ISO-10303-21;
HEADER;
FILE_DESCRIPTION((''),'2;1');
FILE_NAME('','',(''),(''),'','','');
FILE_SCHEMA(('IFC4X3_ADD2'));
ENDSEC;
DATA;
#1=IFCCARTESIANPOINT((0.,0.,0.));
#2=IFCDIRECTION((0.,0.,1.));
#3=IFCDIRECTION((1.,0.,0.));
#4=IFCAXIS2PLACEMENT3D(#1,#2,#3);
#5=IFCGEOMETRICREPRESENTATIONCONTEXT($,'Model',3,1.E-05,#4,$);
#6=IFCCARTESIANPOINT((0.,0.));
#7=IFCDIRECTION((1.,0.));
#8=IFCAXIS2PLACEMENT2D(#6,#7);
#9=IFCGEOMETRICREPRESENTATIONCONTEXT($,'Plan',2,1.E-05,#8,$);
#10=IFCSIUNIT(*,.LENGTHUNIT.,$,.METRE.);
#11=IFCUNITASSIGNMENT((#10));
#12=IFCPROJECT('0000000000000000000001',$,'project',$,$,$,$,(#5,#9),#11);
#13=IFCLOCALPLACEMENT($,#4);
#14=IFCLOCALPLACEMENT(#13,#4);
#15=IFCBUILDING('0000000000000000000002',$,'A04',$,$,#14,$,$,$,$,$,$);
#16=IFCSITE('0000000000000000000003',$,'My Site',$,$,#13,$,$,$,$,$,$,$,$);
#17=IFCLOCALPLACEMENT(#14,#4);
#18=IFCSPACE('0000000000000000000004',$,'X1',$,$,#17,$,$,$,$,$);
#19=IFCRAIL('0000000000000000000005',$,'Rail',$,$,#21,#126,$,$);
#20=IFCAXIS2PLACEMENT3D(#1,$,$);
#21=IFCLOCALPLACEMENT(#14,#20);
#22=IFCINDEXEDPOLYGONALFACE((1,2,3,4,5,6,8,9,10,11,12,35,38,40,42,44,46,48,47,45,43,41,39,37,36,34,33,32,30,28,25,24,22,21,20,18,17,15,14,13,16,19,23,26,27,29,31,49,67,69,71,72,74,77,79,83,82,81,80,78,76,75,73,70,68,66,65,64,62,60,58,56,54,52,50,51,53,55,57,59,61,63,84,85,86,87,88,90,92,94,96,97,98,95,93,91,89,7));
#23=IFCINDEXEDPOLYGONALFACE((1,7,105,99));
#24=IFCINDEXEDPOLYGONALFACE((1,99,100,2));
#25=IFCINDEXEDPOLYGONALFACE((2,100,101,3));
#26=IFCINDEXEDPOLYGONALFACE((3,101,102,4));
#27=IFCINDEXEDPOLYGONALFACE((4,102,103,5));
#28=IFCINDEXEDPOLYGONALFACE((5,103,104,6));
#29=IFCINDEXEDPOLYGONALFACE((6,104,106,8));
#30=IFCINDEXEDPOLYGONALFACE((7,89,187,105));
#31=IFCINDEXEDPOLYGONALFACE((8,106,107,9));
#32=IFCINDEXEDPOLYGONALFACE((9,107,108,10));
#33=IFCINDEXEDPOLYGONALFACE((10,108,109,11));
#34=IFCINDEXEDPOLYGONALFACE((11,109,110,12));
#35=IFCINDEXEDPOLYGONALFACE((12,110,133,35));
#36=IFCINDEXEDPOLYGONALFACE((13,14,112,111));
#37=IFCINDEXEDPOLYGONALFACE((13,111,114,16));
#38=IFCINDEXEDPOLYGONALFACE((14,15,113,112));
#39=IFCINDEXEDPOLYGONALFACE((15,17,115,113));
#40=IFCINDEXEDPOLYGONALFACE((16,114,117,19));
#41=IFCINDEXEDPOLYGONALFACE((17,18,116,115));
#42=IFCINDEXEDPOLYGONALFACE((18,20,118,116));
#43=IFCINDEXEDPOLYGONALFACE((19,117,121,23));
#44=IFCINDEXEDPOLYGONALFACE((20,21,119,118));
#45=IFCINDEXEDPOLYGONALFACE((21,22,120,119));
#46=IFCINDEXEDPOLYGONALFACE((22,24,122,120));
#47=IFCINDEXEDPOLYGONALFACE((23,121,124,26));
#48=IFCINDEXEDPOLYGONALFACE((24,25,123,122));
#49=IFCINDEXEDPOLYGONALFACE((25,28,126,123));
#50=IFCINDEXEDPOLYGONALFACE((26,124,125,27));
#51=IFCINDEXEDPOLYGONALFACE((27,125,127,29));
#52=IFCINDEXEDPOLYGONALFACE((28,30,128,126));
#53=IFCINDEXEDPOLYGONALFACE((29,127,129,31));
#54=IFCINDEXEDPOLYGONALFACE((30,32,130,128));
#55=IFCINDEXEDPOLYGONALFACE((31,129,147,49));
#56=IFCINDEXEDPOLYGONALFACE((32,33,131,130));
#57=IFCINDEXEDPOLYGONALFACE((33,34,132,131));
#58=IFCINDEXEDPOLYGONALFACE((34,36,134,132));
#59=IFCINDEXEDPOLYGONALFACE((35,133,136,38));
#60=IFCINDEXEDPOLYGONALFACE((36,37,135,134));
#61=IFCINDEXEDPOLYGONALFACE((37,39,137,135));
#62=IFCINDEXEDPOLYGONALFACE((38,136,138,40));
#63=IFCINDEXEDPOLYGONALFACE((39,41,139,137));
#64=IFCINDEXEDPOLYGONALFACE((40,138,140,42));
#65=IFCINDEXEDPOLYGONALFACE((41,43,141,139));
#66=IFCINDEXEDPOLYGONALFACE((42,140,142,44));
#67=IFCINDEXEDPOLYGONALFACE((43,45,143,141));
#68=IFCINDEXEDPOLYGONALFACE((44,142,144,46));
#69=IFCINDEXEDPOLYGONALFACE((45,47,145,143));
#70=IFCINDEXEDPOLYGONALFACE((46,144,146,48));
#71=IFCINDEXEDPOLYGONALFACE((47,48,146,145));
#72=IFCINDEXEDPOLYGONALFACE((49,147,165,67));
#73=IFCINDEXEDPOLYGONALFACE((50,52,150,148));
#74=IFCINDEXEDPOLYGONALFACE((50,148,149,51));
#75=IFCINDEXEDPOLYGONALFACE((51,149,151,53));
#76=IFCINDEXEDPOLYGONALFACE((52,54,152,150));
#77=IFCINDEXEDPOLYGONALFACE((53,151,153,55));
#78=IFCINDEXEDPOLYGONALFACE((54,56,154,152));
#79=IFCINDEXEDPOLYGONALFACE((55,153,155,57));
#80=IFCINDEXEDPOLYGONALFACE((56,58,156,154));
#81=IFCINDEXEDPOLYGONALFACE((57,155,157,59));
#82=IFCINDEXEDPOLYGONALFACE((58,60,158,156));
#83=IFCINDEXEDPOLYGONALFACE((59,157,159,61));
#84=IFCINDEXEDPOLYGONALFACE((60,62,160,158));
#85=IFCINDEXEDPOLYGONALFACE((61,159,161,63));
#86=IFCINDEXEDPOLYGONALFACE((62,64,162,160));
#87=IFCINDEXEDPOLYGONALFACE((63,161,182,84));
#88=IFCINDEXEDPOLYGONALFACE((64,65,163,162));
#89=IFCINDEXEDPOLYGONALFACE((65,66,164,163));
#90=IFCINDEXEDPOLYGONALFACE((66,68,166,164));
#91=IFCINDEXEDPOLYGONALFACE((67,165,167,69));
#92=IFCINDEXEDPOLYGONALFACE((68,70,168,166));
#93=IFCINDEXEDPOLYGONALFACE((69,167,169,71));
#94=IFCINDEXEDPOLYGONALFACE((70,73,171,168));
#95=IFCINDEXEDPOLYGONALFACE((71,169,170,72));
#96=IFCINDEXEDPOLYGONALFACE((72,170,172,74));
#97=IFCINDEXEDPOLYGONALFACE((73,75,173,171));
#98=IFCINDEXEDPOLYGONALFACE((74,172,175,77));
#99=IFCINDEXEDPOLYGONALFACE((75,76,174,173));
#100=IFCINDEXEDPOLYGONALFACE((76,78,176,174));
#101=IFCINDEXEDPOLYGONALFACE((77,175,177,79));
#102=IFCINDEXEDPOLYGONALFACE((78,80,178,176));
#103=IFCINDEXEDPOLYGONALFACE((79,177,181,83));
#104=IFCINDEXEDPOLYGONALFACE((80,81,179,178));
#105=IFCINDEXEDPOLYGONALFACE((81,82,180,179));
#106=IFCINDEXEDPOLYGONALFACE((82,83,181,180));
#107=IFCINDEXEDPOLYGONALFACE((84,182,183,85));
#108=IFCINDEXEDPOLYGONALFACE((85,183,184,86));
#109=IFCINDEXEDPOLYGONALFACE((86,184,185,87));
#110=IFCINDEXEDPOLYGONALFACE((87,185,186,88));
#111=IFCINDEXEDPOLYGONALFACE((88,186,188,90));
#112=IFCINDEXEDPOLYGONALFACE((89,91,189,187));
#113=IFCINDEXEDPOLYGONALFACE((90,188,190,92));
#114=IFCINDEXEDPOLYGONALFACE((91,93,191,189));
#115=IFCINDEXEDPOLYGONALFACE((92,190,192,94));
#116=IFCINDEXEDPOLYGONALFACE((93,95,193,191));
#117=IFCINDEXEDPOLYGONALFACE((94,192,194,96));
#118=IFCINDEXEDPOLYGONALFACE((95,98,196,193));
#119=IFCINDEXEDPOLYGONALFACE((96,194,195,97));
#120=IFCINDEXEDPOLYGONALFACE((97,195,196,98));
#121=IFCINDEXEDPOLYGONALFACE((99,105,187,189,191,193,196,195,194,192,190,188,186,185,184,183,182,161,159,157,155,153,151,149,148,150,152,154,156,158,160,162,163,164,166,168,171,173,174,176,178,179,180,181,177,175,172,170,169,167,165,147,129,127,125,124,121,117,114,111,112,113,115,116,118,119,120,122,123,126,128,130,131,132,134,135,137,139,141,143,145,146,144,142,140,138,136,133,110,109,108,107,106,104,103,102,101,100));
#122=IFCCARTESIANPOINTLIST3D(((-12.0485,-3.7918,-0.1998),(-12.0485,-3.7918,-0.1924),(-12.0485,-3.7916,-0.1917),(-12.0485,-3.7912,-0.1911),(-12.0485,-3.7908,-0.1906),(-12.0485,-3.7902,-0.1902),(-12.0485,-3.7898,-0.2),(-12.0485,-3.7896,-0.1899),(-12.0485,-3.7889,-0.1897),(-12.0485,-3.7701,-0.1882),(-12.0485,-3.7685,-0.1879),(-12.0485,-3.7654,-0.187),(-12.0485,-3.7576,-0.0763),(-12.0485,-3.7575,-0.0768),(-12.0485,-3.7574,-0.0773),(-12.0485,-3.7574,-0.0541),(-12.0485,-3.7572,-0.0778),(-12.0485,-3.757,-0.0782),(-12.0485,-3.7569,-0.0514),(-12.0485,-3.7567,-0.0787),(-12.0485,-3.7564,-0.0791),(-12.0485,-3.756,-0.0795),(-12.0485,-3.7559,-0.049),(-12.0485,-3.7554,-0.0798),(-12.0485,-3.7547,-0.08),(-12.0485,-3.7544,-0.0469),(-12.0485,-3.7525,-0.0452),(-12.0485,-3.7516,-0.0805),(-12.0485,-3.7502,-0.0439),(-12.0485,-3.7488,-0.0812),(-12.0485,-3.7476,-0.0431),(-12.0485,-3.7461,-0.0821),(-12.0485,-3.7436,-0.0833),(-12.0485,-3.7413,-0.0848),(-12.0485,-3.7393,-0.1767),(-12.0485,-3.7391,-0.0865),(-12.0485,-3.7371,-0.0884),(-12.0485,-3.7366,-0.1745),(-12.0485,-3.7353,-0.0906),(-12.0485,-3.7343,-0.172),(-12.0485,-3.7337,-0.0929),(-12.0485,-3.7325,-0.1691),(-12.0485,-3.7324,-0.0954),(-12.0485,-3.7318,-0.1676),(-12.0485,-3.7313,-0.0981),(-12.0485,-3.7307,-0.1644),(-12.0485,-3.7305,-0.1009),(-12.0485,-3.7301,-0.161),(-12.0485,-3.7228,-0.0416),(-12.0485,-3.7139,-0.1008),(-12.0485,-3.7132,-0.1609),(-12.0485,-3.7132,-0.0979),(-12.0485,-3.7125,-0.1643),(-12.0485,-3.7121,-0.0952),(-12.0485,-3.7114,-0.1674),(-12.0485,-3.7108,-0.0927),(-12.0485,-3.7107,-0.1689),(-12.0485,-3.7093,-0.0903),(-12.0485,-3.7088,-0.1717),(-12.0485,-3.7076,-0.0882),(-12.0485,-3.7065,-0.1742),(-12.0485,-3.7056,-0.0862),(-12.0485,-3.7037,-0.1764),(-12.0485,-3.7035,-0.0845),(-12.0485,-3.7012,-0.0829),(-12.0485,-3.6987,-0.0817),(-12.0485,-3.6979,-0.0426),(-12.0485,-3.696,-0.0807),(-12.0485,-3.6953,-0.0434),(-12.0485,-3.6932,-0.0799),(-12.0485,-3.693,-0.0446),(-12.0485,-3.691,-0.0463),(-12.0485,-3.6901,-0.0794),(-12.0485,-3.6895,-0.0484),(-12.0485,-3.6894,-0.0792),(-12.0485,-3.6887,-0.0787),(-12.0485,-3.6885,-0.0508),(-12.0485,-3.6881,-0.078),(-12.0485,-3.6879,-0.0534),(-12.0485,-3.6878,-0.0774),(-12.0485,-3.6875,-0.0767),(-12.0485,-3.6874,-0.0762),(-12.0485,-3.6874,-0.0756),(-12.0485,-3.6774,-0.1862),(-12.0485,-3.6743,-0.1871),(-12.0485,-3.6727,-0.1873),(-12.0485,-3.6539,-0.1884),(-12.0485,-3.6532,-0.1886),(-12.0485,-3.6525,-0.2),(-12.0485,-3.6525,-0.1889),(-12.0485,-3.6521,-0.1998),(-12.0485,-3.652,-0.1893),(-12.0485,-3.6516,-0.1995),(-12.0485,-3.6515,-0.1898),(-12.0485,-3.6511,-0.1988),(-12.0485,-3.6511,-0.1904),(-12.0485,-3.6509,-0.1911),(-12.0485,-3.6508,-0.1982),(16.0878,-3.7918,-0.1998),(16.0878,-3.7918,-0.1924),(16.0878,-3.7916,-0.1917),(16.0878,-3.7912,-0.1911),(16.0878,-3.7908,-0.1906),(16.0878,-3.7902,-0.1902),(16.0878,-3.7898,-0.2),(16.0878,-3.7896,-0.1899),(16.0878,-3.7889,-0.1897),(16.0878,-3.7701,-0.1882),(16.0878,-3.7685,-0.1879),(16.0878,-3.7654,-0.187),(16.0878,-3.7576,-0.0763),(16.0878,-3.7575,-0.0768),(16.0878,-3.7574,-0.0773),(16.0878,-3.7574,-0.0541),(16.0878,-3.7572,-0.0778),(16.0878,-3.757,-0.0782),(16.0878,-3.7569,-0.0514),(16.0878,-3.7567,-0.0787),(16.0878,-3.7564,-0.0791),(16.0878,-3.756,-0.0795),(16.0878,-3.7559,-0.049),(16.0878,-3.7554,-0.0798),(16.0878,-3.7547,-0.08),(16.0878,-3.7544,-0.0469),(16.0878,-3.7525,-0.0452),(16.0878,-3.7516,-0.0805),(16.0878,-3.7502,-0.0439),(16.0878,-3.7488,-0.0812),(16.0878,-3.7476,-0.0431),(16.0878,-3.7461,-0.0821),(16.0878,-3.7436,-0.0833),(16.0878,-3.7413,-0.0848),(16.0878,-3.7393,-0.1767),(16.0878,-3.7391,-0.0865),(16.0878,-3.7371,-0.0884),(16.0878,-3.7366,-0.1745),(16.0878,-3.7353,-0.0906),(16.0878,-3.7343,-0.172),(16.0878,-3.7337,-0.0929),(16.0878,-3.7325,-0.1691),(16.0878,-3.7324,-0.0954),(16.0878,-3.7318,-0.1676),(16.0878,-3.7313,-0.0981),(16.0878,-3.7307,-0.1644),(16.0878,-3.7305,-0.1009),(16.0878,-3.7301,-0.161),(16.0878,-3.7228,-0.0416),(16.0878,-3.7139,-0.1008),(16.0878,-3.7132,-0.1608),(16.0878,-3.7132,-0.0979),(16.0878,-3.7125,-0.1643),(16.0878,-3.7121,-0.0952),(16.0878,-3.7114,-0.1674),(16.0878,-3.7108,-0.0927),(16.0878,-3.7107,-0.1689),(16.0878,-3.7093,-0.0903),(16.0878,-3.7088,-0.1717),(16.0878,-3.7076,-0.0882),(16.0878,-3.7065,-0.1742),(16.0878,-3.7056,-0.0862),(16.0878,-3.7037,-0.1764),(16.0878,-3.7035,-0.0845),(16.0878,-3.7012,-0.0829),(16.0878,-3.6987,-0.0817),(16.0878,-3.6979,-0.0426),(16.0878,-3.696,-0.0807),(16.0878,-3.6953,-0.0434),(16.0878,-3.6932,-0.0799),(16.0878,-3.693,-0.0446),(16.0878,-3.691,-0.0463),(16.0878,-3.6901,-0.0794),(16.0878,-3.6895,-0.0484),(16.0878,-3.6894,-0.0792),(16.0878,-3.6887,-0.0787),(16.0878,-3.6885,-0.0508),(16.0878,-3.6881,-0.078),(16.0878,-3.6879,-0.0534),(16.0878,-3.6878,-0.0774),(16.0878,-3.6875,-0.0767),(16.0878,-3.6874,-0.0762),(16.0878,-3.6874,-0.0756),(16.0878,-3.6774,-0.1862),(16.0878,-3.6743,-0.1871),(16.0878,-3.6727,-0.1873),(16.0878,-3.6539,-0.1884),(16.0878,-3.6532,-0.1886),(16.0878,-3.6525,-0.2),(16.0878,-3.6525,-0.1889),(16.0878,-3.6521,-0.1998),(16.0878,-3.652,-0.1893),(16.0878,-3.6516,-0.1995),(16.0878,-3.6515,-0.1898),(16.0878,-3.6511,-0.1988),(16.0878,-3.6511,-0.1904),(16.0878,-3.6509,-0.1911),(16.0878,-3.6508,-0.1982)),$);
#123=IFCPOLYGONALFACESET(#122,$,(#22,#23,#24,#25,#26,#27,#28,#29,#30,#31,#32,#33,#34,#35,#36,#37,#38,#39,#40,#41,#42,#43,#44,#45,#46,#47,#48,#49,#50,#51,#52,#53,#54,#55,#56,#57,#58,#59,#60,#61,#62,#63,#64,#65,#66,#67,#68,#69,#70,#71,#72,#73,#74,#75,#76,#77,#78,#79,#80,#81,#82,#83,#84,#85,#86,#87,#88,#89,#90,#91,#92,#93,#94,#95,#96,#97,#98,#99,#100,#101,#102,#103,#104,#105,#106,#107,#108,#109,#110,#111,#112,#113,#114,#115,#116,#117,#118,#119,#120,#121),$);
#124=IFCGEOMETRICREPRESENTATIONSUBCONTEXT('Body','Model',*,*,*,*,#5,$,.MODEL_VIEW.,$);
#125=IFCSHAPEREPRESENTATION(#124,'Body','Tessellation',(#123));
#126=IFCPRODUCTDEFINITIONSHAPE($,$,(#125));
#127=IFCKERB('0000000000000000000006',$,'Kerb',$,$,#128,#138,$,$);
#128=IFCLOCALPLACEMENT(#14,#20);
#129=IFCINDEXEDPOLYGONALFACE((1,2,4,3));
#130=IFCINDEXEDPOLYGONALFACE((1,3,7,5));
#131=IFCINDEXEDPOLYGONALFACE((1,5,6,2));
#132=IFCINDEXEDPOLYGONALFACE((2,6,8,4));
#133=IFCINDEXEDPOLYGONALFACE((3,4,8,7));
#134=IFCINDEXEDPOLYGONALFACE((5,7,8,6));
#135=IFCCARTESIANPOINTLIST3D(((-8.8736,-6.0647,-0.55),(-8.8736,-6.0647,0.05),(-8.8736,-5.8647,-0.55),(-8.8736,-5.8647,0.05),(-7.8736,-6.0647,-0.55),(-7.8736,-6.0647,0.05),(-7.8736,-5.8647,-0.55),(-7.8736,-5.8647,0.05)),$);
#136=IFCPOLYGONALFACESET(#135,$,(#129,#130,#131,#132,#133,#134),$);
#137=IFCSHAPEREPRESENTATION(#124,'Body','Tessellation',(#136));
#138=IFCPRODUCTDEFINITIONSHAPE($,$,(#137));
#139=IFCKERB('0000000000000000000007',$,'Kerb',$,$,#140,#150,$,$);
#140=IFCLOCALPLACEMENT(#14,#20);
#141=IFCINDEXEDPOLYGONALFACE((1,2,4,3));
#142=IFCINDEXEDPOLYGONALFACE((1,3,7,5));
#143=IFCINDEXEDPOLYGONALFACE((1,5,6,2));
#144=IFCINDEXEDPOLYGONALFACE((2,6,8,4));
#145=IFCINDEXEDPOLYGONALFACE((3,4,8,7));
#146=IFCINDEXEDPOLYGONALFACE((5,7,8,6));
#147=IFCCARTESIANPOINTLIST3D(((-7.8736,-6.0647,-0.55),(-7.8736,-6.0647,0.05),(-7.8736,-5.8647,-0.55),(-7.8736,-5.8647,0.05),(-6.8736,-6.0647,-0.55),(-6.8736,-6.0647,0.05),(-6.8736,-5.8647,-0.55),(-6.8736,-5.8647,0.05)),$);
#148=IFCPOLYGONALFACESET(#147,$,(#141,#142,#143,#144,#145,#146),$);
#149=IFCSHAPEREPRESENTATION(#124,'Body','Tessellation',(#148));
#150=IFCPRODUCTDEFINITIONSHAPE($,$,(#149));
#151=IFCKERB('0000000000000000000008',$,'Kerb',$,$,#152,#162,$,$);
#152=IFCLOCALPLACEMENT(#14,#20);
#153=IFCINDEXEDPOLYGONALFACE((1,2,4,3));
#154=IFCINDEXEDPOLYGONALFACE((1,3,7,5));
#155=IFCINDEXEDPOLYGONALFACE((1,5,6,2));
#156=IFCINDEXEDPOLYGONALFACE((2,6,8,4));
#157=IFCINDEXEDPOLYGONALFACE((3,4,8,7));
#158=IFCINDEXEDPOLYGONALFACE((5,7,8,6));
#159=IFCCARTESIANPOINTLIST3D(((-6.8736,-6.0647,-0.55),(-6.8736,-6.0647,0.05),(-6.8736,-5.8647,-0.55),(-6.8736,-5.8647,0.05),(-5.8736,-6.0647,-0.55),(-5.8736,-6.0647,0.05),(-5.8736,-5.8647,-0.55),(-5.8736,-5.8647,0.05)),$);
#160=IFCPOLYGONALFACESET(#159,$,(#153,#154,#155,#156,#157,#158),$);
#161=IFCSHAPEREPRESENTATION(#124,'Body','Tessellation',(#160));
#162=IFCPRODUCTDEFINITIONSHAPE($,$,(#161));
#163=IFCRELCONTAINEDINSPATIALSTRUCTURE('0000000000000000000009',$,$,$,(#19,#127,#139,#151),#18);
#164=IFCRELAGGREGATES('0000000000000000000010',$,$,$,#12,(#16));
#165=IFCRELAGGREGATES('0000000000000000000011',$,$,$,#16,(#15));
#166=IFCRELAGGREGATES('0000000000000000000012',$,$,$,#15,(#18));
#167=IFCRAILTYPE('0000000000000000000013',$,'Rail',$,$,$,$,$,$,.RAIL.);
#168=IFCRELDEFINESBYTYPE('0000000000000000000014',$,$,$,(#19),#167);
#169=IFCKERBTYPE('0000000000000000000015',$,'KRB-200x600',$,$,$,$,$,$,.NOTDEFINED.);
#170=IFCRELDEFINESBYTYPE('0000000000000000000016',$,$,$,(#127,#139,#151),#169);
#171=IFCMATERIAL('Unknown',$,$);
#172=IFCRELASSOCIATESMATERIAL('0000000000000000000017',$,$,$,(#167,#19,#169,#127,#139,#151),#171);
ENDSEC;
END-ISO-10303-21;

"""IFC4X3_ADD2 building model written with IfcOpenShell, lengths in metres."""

from ifc_helpers import new_model, si_unit, frame, origin_with_axes, origin_2d_with_axis, place, context, subcontext, project, spatial, indexed_curve, rectangle, outline, extrude, material, material_profile, profile_set, profile_usage, type_object, element, save


model = new_model("IFC4X3_ADD2")

# Units and contexts
model_context = context("Model", 3, precision=1e-05, world=origin_with_axes())
plan_context = context("Plan", 2, precision=1e-05, world=origin_2d_with_axis())
body_context = subcontext(model_context, "Body", "Model", "MODEL_VIEW")
ifc_project = project(units=[si_unit("LENGTHUNIT", "METRE")], contexts=[model_context, plan_context])

# Site, building, space
site_placement = place(None, origin_with_axes())
site = spatial("IfcSite", under=ifc_project, at=site_placement, Name="My Site")
building_placement = place(site_placement, origin_with_axes())
building = spatial("IfcBuilding", under=site, at=building_placement, Name="A04")
space_placement = place(building_placement, origin_with_axes())
space = spatial("IfcSpace", under=building, at=space_placement, Name="X1")

# Shared definitions
ifc_material_1 = material(Name="Unknown")

# Rail
ifc_material_profile_1 = material_profile(ifc_material_1, outline(indexed_curve([(-0.0706, 0.0076), (-0.0704, 0.0083), (-0.0701, 0.0089), (-0.0696, 0.0094), (-0.0691, 0.0098), (-0.0684, 0.0101), (-0.0677, 0.0103), (-0.0489, 0.0118), (-0.0474, 0.0121), (-0.0442, 0.013), (-0.0182, 0.0233), (-0.0154, 0.0255), (-0.0131, 0.028), (-0.0113, 0.0309), (-0.0106, 0.0324), (-0.0095, 0.0356), (-0.009, 0.039), (-0.0094, 0.0991), (-0.0102, 0.1019), (-0.0112, 0.1046), (-0.0126, 0.1071), (-0.0141, 0.1094), (-0.0159, 0.1116), (-0.0179, 0.1135), (-0.0201, 0.1152), (-0.0225, 0.1167), (-0.025, 0.1179), (-0.0276, 0.1188), (-0.0304, 0.1195), (-0.0335, 0.12), (-0.0342, 0.1202), (-0.0348, 0.1205), (-0.0353, 0.1209), (-0.0356, 0.1213), (-0.0358, 0.1218), (-0.0361, 0.1222), (-0.0362, 0.1227), (-0.0363, 0.1232), (-0.0364, 0.1237), (-0.0362, 0.1459), (-0.0358, 0.1486), (-0.0347, 0.151), (-0.0333, 0.1531), (-0.0313, 0.1548), (-0.0291, 0.1561), (-0.0265, 0.1569), (-0.0016, 0.1584), (0.0233, 0.1574), (0.0259, 0.1566), (0.0282, 0.1554), (0.0301, 0.1537), (0.0317, 0.1516), (0.0327, 0.1492), (0.0333, 0.1466), (0.0338, 0.1244), (0.0338, 0.1238), (0.0337, 0.1233), (0.0334, 0.1226), (0.0331, 0.122), (0.0325, 0.1213), (0.0317, 0.1208), (0.031, 0.1206), (0.0279, 0.1201), (0.0252, 0.1193), (0.0225, 0.1183), (0.02, 0.1171), (0.0177, 0.1155), (0.0155, 0.1138), (0.0136, 0.1118), (0.0118, 0.1097), (0.0103, 0.1073), (0.009, 0.1048), (0.008, 0.1021), (0.0073, 0.0992), (0.008, 0.0391), (0.0086, 0.0357), (0.0097, 0.0326), (0.0105, 0.0311), (0.0124, 0.0283), (0.0147, 0.0258), (0.0175, 0.0236), (0.0437, 0.0138), (0.0469, 0.0129), (0.0485, 0.0127), (0.0673, 0.0116), (0.068, 0.0114), (0.0686, 0.0111), (0.0692, 0.0107), (0.0697, 0.0102), (0.07, 0.0096), (0.0703, 0.0089), (0.0703, 0.0018), (0.0701, 0.0012), (0.0696, 0.0005), (0.0691, 0.0002), (0.0687, 0.0), (-0.0687, 0.0), (-0.0706, 0.0002), (-0.0706, 0.0076)])))
ifc_profile_set_1 = profile_set([ifc_material_profile_1])
rail_type = type_object("IfcRailType", Name="Rail", PredefinedType="RAIL", material=ifc_profile_set_1)
ifc_profile_usage_1 = profile_usage(ifc_profile_set_1, cardinal=5)
rail_1_placement = place(space_placement, frame((-12.0485, -3.7212, -0.2), z_axis=(1.0, 0.0, 0.0), x_axis=(0.0, 1.0, 0.0)))
element("IfcRail", 1, at=rail_1_placement, inside=space, type_object=rail_type, material=ifc_profile_usage_1, Name="Rail", context=body_context, shape_type="SweptSolid", body=[
    extrude(outline(indexed_curve([(-0.0706, 0.0076), (-0.0704, 0.0083), (-0.0701, 0.0089), (-0.0696, 0.0094), (-0.0691, 0.0098), (-0.0684, 0.0101), (-0.0677, 0.0103), (-0.0489, 0.0118), (-0.0474, 0.0121), (-0.0442, 0.013), (-0.0182, 0.0233), (-0.0154, 0.0255), (-0.0131, 0.028), (-0.0113, 0.0309), (-0.0106, 0.0324), (-0.0095, 0.0356), (-0.009, 0.039), (-0.0094, 0.0991), (-0.0102, 0.1019), (-0.0112, 0.1046), (-0.0126, 0.1071), (-0.0141, 0.1094), (-0.0159, 0.1116), (-0.0179, 0.1135), (-0.0201, 0.1152), (-0.0225, 0.1167), (-0.025, 0.1179), (-0.0276, 0.1188), (-0.0304, 0.1195), (-0.0335, 0.12), (-0.0342, 0.1202), (-0.0348, 0.1205), (-0.0353, 0.1209), (-0.0356, 0.1213), (-0.0358, 0.1218), (-0.0361, 0.1222), (-0.0362, 0.1227), (-0.0363, 0.1232), (-0.0364, 0.1237), (-0.0362, 0.1459), (-0.0358, 0.1486), (-0.0347, 0.151), (-0.0333, 0.1531), (-0.0313, 0.1548), (-0.0291, 0.1561), (-0.0265, 0.1569), (-0.0016, 0.1584), (0.0233, 0.1574), (0.0259, 0.1566), (0.0282, 0.1554), (0.0301, 0.1537), (0.0317, 0.1516), (0.0327, 0.1492), (0.0333, 0.1466), (0.0338, 0.1244), (0.0338, 0.1238), (0.0337, 0.1233), (0.0334, 0.1226), (0.0331, 0.122), (0.0325, 0.1213), (0.0317, 0.1208), (0.031, 0.1206), (0.0279, 0.1201), (0.0252, 0.1193), (0.0225, 0.1183), (0.02, 0.1171), (0.0177, 0.1155), (0.0155, 0.1138), (0.0136, 0.1118), (0.0118, 0.1097), (0.0103, 0.1073), (0.009, 0.1048), (0.008, 0.1021), (0.0073, 0.0992), (0.008, 0.0391), (0.0086, 0.0357), (0.0097, 0.0326), (0.0105, 0.0311), (0.0124, 0.0283), (0.0147, 0.0258), (0.0175, 0.0236), (0.0437, 0.0138), (0.0469, 0.0129), (0.0485, 0.0127), (0.0673, 0.0116), (0.068, 0.0114), (0.0686, 0.0111), (0.0692, 0.0107), (0.0697, 0.0102), (0.07, 0.0096), (0.0703, 0.0089), (0.0703, 0.0018), (0.0701, 0.0012), (0.0696, 0.0005), (0.0691, 0.0002), (0.0687, 0.0), (-0.0687, 0.0), (-0.0706, 0.0002), (-0.0706, 0.0076)])), origin_with_axes(), (0.0, 0.0, 1.0), 28.1363),
])

# Kerbs
ifc_material_profile_2 = material_profile(ifc_material_1, rectangle(XDim=0.2, YDim=0.6))
ifc_profile_set_2 = profile_set([ifc_material_profile_2])
ifc_profile_usage_2 = profile_usage(ifc_profile_set_2, cardinal=2)
kerb_type = type_object("IfcKerbType", Name="KRB-200x600", PredefinedType="NOTDEFINED", material=ifc_profile_set_2)
kerb_1_placement = place(space_placement, frame((-8.8736, -5.9647, -0.55), z_axis=(1.0, 0.0, 0.0), x_axis=(0.0, 1.0, 0.0)))
element("IfcKerb", 2, at=kerb_1_placement, inside=space, type_object=kerb_type, material=ifc_profile_usage_2, Name="Kerb", context=body_context, shape_type="SweptSolid", body=[
    extrude(rectangle(XDim=0.2, YDim=0.6), frame((0.0, 0.3, 0.0), z_axis=(0.0, 0.0, 1.0), x_axis=(1.0, 0.0, 0.0)), (0.0, 0.0, 1.0), 1.0),
])
ifc_profile_usage_3 = profile_usage(ifc_profile_set_2, cardinal=2)
kerb_2_placement = place(space_placement, frame((-7.8736, -5.9647, -0.55), z_axis=(1.0, 0.0, 0.0), x_axis=(0.0, 1.0, 0.0)))
element("IfcKerb", 3, at=kerb_2_placement, inside=space, type_object=kerb_type, material=ifc_profile_usage_3, Name="Kerb", context=body_context, shape_type="SweptSolid", body=[
    extrude(rectangle(XDim=0.2, YDim=0.6), frame((0.0, 0.3, 0.0), z_axis=(0.0, 0.0, 1.0), x_axis=(1.0, 0.0, 0.0)), (0.0, 0.0, 1.0), 1.0),
])
ifc_profile_usage_4 = profile_usage(ifc_profile_set_2, cardinal=2)
kerb_3_placement = place(space_placement, frame((-6.8736, -5.9647, -0.55), z_axis=(1.0, 0.0, 0.0), x_axis=(0.0, 1.0, 0.0)))
element("IfcKerb", 4, at=kerb_3_placement, inside=space, type_object=kerb_type, material=ifc_profile_usage_4, Name="Kerb", context=body_context, shape_type="SweptSolid", body=[
    extrude(rectangle(XDim=0.2, YDim=0.6), frame((0.0, 0.3, 0.0), z_axis=(0.0, 0.0, 1.0), x_axis=(1.0, 0.0, 0.0)), (0.0, 0.0, 1.0), 1.0),
])

save(model, "model.ifc")
